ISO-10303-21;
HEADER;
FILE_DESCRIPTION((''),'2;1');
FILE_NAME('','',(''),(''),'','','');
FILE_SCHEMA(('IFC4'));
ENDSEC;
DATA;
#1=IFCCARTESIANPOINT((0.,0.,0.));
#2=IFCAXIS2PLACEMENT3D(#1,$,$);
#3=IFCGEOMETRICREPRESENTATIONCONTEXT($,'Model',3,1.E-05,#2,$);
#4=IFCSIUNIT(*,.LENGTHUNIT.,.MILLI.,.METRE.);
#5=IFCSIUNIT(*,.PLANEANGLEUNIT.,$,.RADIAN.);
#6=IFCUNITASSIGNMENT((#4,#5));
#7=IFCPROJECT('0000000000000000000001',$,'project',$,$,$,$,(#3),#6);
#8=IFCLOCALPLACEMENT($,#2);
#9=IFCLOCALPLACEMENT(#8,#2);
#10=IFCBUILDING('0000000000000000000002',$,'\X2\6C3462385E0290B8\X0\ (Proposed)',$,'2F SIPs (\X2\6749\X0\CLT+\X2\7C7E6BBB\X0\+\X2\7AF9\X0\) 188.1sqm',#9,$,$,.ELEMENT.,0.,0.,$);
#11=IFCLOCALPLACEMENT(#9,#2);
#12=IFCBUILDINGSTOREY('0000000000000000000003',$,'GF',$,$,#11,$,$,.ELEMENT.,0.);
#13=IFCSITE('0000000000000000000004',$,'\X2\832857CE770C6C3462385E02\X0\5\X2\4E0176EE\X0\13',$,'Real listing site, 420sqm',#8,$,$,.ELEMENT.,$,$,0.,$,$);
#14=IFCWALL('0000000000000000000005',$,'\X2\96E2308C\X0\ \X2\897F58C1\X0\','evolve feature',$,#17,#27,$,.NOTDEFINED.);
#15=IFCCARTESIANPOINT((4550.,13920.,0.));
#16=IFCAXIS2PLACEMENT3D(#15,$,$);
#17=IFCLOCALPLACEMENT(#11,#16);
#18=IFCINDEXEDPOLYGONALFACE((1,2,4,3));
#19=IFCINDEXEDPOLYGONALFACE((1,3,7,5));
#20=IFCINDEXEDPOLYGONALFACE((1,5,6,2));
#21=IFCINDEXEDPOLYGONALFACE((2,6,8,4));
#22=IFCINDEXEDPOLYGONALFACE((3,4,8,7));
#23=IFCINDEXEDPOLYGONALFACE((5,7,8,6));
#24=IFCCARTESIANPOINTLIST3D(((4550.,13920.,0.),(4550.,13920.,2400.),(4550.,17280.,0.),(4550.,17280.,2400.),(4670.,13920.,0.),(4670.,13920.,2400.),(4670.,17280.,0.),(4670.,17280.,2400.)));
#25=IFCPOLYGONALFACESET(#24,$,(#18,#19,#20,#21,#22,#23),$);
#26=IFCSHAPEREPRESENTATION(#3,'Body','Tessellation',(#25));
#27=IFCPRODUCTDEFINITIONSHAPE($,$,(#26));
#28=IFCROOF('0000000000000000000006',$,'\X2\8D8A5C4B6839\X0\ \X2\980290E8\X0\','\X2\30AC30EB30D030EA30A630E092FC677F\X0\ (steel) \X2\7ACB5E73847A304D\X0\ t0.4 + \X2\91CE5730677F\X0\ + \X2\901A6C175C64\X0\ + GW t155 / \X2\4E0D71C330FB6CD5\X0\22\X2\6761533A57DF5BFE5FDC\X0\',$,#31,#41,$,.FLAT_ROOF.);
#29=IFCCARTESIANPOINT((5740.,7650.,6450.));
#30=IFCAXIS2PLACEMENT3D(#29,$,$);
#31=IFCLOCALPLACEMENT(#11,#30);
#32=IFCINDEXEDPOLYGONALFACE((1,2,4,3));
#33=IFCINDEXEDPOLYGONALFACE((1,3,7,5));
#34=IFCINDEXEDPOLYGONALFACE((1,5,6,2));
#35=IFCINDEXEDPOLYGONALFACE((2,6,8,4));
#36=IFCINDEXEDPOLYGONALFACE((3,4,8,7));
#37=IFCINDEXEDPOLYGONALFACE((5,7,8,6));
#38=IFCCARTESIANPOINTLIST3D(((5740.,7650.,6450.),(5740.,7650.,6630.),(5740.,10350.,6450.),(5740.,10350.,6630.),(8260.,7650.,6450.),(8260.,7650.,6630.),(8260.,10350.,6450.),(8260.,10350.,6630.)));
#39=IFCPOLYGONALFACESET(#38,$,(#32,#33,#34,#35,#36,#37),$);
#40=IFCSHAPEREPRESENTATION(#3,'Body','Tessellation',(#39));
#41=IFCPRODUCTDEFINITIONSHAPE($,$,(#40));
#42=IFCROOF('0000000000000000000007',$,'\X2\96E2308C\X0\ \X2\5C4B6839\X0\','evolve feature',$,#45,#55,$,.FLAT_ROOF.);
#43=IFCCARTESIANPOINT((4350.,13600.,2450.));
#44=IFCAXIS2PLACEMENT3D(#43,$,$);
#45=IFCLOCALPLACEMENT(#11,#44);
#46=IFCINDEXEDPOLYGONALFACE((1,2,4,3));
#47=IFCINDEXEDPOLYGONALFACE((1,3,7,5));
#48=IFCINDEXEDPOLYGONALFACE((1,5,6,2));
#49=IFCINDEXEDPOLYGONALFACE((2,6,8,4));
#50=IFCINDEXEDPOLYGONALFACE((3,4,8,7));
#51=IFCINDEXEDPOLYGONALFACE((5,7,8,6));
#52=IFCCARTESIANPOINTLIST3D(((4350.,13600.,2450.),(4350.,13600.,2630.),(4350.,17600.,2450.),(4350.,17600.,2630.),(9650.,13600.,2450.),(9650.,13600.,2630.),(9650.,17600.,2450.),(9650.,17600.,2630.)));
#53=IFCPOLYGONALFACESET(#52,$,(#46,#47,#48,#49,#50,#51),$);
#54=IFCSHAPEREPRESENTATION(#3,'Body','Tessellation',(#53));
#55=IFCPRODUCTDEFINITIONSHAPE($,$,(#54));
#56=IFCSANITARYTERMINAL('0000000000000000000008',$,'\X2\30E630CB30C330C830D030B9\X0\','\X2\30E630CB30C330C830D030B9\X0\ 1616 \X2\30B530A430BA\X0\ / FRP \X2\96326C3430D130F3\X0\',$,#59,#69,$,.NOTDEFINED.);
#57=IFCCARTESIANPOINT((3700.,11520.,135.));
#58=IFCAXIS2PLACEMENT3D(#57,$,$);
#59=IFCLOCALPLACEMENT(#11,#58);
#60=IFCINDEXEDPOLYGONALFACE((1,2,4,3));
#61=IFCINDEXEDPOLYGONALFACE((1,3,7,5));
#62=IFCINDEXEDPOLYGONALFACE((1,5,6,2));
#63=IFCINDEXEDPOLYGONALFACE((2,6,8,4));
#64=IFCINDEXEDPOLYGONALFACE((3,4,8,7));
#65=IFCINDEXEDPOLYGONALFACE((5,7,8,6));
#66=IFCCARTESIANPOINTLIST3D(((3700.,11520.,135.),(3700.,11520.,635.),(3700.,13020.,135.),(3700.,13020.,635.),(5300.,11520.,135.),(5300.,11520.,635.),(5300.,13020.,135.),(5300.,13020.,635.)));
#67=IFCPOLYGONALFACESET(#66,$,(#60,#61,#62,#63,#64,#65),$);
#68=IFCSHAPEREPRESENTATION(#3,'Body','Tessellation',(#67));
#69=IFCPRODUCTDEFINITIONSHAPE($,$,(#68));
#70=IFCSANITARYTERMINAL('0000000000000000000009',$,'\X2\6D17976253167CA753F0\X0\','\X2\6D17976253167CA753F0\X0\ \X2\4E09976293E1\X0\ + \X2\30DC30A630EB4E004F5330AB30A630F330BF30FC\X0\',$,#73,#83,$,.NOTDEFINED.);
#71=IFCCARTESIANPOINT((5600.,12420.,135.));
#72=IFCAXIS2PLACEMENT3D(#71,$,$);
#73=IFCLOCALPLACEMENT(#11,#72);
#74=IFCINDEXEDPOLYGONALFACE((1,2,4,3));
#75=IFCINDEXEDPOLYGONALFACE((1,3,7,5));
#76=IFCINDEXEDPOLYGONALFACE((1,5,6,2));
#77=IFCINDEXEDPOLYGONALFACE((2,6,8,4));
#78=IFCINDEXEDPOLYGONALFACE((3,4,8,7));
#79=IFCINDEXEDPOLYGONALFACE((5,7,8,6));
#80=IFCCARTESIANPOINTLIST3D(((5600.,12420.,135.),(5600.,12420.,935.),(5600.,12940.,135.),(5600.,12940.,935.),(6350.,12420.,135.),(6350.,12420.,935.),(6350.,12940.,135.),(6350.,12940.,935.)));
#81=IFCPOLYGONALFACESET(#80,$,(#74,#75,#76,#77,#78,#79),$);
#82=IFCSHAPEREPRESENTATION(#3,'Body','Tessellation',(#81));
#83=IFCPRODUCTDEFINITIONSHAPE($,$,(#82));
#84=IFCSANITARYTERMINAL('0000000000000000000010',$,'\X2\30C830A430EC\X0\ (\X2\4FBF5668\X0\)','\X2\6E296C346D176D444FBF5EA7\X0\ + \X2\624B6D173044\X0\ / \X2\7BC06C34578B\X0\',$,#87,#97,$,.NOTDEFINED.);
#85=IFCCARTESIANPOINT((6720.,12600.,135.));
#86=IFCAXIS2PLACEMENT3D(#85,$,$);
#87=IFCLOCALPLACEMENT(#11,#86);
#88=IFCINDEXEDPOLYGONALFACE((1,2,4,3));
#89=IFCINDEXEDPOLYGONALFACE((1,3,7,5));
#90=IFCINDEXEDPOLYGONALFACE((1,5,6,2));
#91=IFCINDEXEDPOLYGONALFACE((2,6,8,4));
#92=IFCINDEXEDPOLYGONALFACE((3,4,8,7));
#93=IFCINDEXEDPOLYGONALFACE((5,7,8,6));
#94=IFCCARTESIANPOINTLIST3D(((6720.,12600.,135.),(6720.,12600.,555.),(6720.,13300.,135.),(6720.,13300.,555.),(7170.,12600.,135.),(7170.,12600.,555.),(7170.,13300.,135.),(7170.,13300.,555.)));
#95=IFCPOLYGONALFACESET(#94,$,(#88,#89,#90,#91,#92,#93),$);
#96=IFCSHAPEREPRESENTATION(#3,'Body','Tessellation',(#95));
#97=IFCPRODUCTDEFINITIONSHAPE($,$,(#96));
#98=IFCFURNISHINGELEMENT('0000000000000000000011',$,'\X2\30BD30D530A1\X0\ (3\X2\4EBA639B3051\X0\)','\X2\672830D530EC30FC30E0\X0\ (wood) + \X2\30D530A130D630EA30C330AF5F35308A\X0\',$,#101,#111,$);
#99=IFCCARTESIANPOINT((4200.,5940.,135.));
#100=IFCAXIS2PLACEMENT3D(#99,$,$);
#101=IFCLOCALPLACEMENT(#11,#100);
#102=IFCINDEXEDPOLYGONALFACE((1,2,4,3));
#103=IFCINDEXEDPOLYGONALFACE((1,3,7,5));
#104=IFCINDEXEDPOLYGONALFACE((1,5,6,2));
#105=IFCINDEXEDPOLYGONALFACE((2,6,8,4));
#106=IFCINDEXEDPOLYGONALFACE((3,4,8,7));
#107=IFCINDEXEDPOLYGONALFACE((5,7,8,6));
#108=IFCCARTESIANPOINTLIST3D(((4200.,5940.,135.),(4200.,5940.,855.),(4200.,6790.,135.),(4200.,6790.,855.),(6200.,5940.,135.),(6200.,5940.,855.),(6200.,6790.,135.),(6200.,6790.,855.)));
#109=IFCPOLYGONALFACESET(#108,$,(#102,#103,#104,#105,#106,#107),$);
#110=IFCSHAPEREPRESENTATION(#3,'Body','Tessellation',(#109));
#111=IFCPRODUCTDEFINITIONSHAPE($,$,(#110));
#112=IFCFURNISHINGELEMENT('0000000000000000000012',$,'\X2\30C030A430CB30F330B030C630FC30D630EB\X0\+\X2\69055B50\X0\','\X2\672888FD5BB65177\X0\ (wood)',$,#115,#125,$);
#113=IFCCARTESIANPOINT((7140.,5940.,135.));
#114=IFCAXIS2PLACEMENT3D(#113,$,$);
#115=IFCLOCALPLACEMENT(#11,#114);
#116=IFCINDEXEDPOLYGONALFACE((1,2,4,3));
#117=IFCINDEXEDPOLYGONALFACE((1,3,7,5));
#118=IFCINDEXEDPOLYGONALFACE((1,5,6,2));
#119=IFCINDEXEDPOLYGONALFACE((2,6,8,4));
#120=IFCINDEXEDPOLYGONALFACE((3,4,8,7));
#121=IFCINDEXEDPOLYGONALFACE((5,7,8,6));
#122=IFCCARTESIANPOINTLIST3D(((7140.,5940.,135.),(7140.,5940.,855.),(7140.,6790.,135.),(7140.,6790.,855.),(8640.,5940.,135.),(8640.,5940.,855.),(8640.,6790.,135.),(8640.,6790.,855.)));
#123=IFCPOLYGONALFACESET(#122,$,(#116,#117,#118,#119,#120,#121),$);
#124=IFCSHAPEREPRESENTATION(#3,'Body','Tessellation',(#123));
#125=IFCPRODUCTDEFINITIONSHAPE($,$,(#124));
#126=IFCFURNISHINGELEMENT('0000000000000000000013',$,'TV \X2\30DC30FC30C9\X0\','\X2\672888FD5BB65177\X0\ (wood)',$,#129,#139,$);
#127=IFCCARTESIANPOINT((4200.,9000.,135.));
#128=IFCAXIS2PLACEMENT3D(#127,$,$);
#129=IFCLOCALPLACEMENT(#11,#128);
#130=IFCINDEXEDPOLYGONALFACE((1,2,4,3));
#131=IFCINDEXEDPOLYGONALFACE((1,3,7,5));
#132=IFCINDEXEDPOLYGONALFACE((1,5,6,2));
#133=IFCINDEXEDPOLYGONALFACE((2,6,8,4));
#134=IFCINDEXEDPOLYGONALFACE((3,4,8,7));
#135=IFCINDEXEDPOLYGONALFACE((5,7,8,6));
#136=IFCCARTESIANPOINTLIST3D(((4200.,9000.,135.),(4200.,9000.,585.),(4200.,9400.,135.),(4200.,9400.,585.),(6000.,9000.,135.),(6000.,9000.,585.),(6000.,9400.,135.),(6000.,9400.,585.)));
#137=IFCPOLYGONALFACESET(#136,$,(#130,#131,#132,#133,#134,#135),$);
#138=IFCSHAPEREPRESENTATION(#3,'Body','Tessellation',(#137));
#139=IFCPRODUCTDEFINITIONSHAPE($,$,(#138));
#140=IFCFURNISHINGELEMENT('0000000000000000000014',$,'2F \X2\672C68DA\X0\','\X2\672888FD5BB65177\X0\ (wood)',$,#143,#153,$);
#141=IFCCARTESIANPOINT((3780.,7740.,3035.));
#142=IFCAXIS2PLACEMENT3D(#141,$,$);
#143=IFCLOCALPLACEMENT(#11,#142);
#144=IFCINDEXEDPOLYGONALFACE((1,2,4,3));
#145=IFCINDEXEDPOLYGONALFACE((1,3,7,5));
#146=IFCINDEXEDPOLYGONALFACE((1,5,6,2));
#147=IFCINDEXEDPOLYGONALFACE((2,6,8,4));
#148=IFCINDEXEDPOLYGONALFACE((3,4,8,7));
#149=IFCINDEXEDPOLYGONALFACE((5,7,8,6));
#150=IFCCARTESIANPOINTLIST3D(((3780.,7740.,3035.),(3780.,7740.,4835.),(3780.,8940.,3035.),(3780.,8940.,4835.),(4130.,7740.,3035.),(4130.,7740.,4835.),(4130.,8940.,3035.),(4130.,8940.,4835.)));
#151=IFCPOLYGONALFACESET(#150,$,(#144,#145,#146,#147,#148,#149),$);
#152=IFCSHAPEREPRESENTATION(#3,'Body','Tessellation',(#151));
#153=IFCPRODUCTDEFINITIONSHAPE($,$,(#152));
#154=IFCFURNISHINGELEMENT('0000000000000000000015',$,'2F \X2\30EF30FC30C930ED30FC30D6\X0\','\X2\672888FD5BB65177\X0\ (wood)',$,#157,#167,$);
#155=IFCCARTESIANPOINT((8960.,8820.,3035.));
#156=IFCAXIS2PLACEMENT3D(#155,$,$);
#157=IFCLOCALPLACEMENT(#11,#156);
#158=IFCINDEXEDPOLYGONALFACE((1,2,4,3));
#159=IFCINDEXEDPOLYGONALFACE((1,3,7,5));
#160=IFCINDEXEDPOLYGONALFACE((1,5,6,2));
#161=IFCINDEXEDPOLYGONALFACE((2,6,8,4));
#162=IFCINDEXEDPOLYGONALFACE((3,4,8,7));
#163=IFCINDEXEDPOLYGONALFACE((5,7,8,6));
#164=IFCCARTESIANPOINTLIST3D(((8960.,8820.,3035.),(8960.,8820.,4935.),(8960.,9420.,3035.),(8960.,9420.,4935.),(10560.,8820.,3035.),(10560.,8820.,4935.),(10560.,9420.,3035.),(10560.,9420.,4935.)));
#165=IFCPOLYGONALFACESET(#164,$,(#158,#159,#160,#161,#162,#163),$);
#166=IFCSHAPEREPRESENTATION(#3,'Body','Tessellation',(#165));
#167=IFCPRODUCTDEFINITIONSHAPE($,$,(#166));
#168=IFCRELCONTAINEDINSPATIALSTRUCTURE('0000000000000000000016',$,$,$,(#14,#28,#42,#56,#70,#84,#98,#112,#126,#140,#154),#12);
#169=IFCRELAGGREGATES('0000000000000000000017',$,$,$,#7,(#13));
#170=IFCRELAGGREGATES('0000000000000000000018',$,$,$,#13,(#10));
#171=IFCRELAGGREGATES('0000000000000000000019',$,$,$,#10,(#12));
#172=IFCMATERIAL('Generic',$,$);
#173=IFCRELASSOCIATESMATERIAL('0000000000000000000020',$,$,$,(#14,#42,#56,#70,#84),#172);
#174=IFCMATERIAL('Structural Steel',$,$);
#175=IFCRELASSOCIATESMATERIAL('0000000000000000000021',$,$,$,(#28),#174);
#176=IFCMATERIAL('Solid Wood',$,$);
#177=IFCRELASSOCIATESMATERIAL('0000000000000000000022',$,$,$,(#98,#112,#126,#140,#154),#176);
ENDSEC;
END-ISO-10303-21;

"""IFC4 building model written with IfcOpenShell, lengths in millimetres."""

from ifc_helpers import new_model, si_unit, frame, frame_2d, origin, place, context, project, spatial, rectangle, extrude, material, element, save


model = new_model("IFC4")

# Units and contexts
model_context = context("Model", 3, precision=1e-05, world=origin())
ifc_project = project(units=[si_unit("LENGTHUNIT", "METRE", prefix="MILLI"), si_unit("PLANEANGLEUNIT", "RADIAN")], contexts=[model_context])

# Site, building, storey
site_placement = place(None, origin())
site = spatial("IfcSite", under=ifc_project, at=site_placement, Name="茨城県水戸市5丁目13", ObjectType="Real listing site, 420sqm", CompositionType="ELEMENT", RefElevation=0.0)
building_placement = place(site_placement, origin())
building = spatial("IfcBuilding", under=site, at=building_placement, Name="水戸市邸 (Proposed)", ObjectType="2F SIPs (杉CLT+籾殻+竹) 188.1sqm", CompositionType="ELEMENT", ElevationOfRefHeight=0.0, ElevationOfTerrain=0.0)
storey_placement = place(building_placement, origin())
storey = spatial("IfcBuildingStorey", under=building, at=storey_placement, Name="GF", CompositionType="ELEMENT", Elevation=0.0)

# Shared definitions
ifc_material_1 = material(Name="Generic")

# Shared definitions
ifc_material_2 = material(Name="Solid Wood")

# Wall
wall_1_placement = place(storey_placement, frame((4550.0, 13920.0, 0.0)))
element("IfcWall", 1, at=wall_1_placement, inside=storey, material=ifc_material_1, Name="離れ 西壁", Description="evolve feature", PredefinedType="NOTDEFINED", context=model_context, shape_type="SweptSolid", body=[
    extrude(rectangle(XDim=120.0, YDim=3360.0, at=frame_2d((60.0, 1680.0))), frame((4550.0, 13920.0, 0.0)), (0.0, 0.0, 1.0), 2400.0),
])

# Roofs
ifc_material_3 = material(Name="Structural Steel")
roof_1_placement = place(storey_placement, frame((5740.0, 7650.0, 6450.0)))
element("IfcRoof", 2, at=roof_1_placement, inside=storey, material=ifc_material_3, Name="越屋根 頂部", Description="ガルバリウム鋼板 (steel) 立平葺き t0.4 + 野地板 + 通気層 + GW t155 / 不燃・法22条区域対応", PredefinedType="FLAT_ROOF", context=model_context, shape_type="SweptSolid", body=[
    extrude(rectangle(XDim=2520.0, YDim=2700.0, at=frame_2d((1260.0, 1350.0))), frame((5740.0, 7650.0, 6450.0)), (0.0, 0.0, 1.0), 180.0),
])
roof_2_placement = place(storey_placement, frame((4350.0, 13600.0, 2450.0)))
element("IfcRoof", 3, at=roof_2_placement, inside=storey, material=ifc_material_1, Name="離れ 屋根", Description="evolve feature", PredefinedType="FLAT_ROOF", context=model_context, shape_type="SweptSolid", body=[
    extrude(rectangle(XDim=5300.0, YDim=4000.0, at=frame_2d((2650.0, 2000.0))), frame((4350.0, 13600.0, 2450.0)), (0.0, 0.0, 1.0), 180.0),
])

# Sanitary terminals
sanitary_terminal_1_placement = place(storey_placement, frame((3700.0, 11520.0, 135.0)))
element("IfcSanitaryTerminal", 4, at=sanitary_terminal_1_placement, inside=storey, material=ifc_material_1, Name="ユニットバス", Description="ユニットバス 1616 サイズ / FRP 防水パン", PredefinedType="NOTDEFINED", context=model_context, shape_type="SweptSolid", body=[
    extrude(rectangle(XDim=1600.0, YDim=1500.0, at=frame_2d((800.0, 750.0))), frame((3700.0, 11520.0, 135.0)), (0.0, 0.0, 1.0), 500.0),
])
sanitary_terminal_2_placement = place(storey_placement, frame((5600.0, 12420.0, 135.0)))
element("IfcSanitaryTerminal", 5, at=sanitary_terminal_2_placement, inside=storey, material=ifc_material_1, Name="洗面化粧台", Description="洗面化粧台 三面鏡 + ボウル一体カウンター", PredefinedType="NOTDEFINED", context=model_context, shape_type="SweptSolid", body=[
    extrude(rectangle(XDim=750.0, YDim=520.0, at=frame_2d((375.0, 260.0))), frame((5600.0, 12420.0, 135.0)), (0.0, 0.0, 1.0), 800.0),
])
sanitary_terminal_3_placement = place(storey_placement, frame((6720.0, 12600.0, 135.0)))
element("IfcSanitaryTerminal", 6, at=sanitary_terminal_3_placement, inside=storey, material=ifc_material_1, Name="トイレ (便器)", Description="温水洗浄便座 + 手洗い / 節水型", PredefinedType="NOTDEFINED", context=model_context, shape_type="SweptSolid", body=[
    extrude(rectangle(XDim=450.0, YDim=700.0, at=frame_2d((225.0, 350.0))), frame((6720.0, 12600.0, 135.0)), (0.0, 0.0, 1.0), 420.0),
])

# Furnishing elements
furnishing_1_placement = place(storey_placement, frame((4200.0, 5940.0, 135.0)))
element("IfcFurnishingElement", 7, at=furnishing_1_placement, inside=storey, material=ifc_material_2, Name="ソファ (3人掛け)", Description="木フレーム (wood) + ファブリック張り", context=model_context, shape_type="SweptSolid", body=[
    extrude(rectangle(XDim=2000.0, YDim=850.0, at=frame_2d((1000.0, 425.0))), frame((4200.0, 5940.0, 135.0)), (0.0, 0.0, 1.0), 720.0),
])
furnishing_2_placement = place(storey_placement, frame((7140.0, 5940.0, 135.0)))
element("IfcFurnishingElement", 8, at=furnishing_2_placement, inside=storey, material=ifc_material_2, Name="ダイニングテーブル+椅子", Description="木製家具 (wood)", context=model_context, shape_type="SweptSolid", body=[
    extrude(rectangle(XDim=1500.0, YDim=850.0, at=frame_2d((750.0, 425.0))), frame((7140.0, 5940.0, 135.0)), (0.0, 0.0, 1.0), 720.0),
])
furnishing_3_placement = place(storey_placement, frame((4200.0, 9000.0, 135.0)))
element("IfcFurnishingElement", 9, at=furnishing_3_placement, inside=storey, material=ifc_material_2, Name="TV ボード", Description="木製家具 (wood)", context=model_context, shape_type="SweptSolid", body=[
    extrude(rectangle(XDim=1800.0, YDim=400.0, at=frame_2d((900.0, 200.0))), frame((4200.0, 9000.0, 135.0)), (0.0, 0.0, 1.0), 450.0),
])
furnishing_4_placement = place(storey_placement, frame((3780.0, 7740.0, 3035.0)))
element("IfcFurnishingElement", 10, at=furnishing_4_placement, inside=storey, material=ifc_material_2, Name="2F 本棚", Description="木製家具 (wood)", context=model_context, shape_type="SweptSolid", body=[
    extrude(rectangle(XDim=350.0, YDim=1200.0, at=frame_2d((175.0, 600.0))), frame((3780.0, 7740.0, 3035.0)), (0.0, 0.0, 1.0), 1800.0),
])
furnishing_5_placement = place(storey_placement, frame((8960.0, 8820.0, 3035.0)))
element("IfcFurnishingElement", 11, at=furnishing_5_placement, inside=storey, material=ifc_material_2, Name="2F ワードローブ", Description="木製家具 (wood)", context=model_context, shape_type="SweptSolid", body=[
    extrude(rectangle(XDim=1600.0, YDim=600.0, at=frame_2d((800.0, 300.0))), frame((8960.0, 8820.0, 3035.0)), (0.0, 0.0, 1.0), 1900.0),
])

save(model, "model.ifc")
